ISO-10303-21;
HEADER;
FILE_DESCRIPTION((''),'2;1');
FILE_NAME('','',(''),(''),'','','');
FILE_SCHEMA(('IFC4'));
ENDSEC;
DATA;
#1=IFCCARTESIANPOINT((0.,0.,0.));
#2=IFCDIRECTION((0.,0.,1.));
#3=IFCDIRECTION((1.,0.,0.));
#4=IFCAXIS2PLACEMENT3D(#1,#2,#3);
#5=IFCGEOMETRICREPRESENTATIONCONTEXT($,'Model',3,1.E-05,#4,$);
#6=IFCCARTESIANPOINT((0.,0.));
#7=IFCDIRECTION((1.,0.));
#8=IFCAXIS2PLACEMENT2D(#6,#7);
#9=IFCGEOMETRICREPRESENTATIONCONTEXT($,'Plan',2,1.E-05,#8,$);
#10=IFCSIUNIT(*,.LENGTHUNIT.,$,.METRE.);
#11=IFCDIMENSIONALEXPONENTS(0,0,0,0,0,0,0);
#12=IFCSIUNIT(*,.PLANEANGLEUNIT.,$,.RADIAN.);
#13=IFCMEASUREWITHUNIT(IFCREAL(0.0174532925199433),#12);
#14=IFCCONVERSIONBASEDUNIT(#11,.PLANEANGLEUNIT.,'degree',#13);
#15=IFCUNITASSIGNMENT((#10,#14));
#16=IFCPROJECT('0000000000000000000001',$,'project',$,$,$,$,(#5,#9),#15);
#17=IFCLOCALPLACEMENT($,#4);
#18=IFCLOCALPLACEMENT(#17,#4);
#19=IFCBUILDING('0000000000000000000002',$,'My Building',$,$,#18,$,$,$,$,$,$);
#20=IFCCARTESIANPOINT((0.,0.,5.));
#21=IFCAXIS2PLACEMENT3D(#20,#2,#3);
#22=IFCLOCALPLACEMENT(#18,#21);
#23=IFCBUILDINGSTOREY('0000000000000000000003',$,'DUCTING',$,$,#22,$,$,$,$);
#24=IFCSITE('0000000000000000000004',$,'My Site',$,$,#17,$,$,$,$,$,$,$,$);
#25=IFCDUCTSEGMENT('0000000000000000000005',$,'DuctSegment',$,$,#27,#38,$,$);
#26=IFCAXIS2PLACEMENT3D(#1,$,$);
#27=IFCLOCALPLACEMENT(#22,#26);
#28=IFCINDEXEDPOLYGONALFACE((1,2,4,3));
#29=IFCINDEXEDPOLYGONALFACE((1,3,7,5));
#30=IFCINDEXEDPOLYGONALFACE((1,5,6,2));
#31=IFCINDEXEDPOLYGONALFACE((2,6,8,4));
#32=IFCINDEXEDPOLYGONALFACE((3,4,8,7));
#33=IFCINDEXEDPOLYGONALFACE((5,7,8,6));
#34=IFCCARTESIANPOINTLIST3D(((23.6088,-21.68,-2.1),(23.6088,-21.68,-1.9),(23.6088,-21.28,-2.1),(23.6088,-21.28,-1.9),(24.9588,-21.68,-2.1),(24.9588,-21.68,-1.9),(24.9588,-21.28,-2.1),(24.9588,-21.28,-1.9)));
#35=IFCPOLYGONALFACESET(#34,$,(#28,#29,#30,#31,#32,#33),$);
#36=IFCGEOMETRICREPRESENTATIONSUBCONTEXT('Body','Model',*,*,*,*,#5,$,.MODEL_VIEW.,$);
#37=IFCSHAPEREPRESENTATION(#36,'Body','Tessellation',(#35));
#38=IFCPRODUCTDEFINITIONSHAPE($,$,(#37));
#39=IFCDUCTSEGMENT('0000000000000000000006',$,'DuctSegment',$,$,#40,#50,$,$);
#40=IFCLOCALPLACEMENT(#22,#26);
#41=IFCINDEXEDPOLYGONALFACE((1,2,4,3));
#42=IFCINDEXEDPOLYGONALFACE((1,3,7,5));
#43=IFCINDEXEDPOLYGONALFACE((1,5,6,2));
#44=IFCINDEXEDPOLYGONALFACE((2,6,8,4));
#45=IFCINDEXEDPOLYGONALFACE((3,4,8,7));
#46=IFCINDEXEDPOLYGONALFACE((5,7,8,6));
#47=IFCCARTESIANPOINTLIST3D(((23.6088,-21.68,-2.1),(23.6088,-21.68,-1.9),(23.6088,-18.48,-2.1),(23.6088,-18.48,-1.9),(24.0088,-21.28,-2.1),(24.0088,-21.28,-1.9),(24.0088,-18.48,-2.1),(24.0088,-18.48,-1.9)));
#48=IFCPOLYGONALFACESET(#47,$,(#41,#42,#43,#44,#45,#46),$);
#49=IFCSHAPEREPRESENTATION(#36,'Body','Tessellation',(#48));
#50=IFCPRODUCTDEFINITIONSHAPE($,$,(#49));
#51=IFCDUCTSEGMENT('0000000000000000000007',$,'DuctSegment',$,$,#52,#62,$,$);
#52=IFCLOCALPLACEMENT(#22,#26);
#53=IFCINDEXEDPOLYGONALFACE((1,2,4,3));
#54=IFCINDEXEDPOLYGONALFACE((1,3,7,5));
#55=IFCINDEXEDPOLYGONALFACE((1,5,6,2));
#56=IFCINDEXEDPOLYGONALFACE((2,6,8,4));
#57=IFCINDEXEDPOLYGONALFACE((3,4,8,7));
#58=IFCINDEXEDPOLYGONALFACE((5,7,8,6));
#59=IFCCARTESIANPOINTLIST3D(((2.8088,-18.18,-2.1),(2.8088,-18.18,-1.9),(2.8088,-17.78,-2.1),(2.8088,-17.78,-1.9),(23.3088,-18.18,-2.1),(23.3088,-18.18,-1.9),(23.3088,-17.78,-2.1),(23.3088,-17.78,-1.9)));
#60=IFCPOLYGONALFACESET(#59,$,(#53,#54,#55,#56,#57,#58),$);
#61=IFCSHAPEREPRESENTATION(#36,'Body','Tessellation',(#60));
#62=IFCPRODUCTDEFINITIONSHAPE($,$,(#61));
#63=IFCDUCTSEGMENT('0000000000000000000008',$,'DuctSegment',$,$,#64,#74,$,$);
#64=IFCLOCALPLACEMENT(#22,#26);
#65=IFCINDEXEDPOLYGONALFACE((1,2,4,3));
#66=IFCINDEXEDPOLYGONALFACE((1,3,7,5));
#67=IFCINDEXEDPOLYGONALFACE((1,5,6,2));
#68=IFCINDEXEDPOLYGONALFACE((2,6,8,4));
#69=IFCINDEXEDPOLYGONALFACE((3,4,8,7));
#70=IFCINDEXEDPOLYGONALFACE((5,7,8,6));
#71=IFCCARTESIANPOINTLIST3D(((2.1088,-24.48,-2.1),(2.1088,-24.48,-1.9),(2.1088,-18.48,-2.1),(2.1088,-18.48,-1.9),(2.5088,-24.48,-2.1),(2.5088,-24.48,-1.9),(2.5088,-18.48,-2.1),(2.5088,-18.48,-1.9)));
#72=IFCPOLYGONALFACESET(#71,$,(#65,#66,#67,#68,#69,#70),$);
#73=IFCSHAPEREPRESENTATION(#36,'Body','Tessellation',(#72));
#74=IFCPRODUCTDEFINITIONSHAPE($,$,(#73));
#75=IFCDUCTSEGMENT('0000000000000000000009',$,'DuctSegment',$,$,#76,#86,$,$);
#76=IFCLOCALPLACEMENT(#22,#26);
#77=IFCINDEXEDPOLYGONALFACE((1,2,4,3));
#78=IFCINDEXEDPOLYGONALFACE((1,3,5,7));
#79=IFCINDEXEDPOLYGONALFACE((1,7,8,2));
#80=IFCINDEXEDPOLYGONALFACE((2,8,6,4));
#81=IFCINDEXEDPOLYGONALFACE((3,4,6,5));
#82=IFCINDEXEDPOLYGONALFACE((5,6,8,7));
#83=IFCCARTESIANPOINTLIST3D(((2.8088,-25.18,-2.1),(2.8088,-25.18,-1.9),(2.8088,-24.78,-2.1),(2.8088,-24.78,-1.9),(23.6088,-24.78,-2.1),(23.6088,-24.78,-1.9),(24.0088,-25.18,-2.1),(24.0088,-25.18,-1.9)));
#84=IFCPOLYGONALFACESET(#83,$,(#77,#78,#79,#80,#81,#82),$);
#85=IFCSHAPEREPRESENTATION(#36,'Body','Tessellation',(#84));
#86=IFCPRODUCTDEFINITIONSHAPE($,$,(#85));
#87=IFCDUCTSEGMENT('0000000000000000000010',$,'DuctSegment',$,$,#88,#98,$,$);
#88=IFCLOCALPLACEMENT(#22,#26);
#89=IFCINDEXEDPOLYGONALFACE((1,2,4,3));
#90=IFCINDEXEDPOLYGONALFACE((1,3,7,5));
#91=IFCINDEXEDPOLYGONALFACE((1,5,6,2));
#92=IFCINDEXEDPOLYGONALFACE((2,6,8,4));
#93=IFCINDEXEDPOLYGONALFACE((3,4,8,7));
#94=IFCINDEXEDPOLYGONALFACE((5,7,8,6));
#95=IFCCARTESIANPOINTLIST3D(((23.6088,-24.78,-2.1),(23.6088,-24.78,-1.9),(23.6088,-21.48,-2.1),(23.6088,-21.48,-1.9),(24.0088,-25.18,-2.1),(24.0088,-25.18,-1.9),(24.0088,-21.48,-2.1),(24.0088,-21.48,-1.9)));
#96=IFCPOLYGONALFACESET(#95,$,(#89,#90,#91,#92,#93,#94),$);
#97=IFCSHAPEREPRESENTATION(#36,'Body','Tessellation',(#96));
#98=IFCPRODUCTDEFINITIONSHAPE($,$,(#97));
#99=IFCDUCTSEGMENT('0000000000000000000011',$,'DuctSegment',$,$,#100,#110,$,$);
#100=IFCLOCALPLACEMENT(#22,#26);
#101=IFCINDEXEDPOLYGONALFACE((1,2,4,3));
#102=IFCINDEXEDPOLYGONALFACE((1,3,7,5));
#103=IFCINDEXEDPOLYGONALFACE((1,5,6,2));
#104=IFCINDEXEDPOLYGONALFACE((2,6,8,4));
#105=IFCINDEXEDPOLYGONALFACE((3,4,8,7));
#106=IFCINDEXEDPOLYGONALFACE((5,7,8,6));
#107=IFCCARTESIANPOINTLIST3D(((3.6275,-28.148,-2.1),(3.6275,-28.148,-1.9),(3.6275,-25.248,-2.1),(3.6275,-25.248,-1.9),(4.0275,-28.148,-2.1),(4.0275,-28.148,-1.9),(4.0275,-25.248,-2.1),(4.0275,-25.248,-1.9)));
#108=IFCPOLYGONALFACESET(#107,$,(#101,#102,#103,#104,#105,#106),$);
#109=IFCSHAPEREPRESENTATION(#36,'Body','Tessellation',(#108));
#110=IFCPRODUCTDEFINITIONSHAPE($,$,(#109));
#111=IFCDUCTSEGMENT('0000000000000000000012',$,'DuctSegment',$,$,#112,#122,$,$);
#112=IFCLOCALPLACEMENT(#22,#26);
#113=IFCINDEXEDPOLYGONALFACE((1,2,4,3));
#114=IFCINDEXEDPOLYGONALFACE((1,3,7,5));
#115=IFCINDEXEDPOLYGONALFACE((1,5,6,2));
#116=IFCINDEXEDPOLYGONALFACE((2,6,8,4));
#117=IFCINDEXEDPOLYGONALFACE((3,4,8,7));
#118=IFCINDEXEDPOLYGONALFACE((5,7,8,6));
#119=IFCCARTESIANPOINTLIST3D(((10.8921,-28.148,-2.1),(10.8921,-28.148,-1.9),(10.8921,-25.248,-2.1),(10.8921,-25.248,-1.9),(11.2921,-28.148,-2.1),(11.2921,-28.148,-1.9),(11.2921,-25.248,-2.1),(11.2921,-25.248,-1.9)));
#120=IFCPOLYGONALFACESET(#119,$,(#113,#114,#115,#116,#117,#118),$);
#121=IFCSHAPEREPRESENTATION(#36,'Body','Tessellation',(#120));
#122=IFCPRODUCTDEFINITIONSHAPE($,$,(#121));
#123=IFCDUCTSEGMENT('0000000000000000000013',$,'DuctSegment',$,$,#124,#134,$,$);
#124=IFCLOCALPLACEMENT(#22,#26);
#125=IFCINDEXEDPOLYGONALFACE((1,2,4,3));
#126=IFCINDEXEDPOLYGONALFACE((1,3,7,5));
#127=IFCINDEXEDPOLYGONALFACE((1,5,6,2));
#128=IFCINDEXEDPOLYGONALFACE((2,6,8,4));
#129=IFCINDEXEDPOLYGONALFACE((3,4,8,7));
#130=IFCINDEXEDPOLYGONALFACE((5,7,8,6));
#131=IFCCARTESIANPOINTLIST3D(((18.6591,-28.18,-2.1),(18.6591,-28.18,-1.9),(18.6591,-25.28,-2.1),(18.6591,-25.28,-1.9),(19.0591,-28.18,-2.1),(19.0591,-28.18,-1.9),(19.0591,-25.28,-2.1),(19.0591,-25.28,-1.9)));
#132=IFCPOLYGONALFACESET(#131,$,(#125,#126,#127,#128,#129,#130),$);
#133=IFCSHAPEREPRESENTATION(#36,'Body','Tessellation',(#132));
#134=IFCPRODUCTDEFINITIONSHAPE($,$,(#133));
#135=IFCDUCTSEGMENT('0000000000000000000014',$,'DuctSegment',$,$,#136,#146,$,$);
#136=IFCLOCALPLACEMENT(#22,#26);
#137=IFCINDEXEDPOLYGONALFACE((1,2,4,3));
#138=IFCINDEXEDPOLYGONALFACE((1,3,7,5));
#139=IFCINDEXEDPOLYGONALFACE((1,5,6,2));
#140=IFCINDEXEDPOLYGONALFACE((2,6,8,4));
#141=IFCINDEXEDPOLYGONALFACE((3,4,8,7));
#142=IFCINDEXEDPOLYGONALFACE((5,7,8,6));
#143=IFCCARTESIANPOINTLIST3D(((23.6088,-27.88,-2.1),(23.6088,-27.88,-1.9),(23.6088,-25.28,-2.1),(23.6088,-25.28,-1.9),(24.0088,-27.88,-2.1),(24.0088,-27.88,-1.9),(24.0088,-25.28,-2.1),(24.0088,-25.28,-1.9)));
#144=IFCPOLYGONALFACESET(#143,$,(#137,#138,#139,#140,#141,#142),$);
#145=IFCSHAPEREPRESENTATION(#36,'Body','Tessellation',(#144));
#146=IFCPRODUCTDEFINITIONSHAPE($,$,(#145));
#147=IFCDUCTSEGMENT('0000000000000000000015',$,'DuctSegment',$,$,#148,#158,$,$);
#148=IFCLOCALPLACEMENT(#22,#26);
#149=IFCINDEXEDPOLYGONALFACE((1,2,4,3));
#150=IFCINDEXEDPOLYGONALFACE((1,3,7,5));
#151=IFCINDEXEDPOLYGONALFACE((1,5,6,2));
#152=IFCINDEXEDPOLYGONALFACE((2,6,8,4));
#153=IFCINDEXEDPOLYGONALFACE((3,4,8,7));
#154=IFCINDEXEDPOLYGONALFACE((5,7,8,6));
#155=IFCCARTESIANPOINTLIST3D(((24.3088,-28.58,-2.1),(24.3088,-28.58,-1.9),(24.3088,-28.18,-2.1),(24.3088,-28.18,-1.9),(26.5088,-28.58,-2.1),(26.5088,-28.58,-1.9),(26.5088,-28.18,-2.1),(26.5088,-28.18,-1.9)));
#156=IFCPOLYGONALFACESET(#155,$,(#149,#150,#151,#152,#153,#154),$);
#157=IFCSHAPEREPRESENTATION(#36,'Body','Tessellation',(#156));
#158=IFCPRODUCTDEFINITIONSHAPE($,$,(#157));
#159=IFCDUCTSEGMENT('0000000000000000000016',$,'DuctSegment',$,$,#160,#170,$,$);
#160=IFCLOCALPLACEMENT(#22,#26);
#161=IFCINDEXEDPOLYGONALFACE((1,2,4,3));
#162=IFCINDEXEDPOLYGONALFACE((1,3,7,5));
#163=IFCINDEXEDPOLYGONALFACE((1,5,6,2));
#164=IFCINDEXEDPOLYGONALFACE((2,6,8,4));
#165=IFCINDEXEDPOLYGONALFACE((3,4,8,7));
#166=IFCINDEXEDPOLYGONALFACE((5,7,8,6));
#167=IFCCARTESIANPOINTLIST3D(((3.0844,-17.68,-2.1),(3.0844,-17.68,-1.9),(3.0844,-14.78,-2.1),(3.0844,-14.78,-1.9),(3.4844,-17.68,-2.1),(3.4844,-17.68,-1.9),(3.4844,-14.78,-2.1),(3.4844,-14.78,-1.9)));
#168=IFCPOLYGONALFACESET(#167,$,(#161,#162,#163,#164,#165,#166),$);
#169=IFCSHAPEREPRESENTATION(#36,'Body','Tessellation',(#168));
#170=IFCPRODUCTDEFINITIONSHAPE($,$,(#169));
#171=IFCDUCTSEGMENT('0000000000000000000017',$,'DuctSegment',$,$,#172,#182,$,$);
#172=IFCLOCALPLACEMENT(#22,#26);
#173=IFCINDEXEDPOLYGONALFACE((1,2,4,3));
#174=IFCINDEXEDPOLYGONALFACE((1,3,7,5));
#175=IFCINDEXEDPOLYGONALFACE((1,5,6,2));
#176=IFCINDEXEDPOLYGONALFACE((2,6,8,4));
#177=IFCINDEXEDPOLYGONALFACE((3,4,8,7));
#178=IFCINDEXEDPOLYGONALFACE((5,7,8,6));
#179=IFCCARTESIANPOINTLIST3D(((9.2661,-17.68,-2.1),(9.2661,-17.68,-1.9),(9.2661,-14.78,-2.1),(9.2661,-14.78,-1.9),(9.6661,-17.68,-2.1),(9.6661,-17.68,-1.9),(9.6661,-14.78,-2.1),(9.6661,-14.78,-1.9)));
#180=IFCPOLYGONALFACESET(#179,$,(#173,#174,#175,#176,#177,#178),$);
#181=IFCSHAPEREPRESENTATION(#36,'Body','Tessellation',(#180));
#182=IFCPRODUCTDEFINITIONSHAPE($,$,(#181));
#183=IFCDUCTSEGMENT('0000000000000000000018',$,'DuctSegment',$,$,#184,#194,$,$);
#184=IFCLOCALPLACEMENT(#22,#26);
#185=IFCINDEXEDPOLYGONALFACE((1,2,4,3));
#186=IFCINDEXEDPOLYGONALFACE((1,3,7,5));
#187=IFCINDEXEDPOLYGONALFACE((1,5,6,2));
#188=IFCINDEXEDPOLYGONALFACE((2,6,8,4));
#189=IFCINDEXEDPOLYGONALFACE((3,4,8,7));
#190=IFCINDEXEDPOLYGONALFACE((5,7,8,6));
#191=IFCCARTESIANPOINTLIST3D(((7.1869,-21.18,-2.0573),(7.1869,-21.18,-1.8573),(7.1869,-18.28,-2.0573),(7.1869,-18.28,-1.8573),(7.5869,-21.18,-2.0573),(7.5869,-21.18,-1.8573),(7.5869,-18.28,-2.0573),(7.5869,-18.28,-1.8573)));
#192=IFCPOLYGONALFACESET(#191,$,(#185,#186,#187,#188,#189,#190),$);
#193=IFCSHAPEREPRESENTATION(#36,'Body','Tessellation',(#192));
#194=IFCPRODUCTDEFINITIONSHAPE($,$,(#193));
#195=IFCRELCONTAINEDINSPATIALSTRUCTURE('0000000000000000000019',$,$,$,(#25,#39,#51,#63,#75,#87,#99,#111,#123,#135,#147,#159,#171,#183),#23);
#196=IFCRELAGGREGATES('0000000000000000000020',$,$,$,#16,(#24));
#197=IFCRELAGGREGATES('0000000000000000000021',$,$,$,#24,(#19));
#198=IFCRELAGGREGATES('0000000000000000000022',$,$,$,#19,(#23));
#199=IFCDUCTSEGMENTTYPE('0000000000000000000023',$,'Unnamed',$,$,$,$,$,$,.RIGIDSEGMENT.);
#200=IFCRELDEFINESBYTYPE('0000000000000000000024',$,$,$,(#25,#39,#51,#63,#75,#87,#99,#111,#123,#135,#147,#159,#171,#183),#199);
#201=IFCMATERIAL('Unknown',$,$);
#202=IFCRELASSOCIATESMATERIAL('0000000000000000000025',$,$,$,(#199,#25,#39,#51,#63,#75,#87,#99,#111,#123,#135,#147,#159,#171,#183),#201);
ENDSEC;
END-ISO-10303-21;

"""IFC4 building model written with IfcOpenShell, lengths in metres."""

from ifc_helpers import new_model, entity, si_unit, converted_unit, frame, origin_with_axes, origin_2d_with_axis, place, context, subcontext, project, spatial, rectangle, extrude, clip, halfspace, material, material_profile, profile_set, profile_usage, type_object, element, save


model = new_model("IFC4")

# Units and contexts
model_context = context("Model", 3, precision=1e-05, world=origin_with_axes())
plan_context = context("Plan", 2, precision=1e-05, world=origin_2d_with_axis())
body_context = subcontext(model_context, "Body", "Model", "MODEL_VIEW")
ifc_project = project(units=[si_unit("LENGTHUNIT", "METRE"), converted_unit("PLANEANGLEUNIT", "degree", entity("IfcReal", 0.0174532925199433), si_unit("PLANEANGLEUNIT", "RADIAN"), dimensions=[0, 0, 0, 0, 0, 0, 0])], contexts=[model_context, plan_context])

# Site, building, storey
site_placement = place(None, origin_with_axes())
site = spatial("IfcSite", under=ifc_project, at=site_placement, Name="My Site")
building_placement = place(site_placement, origin_with_axes())
building = spatial("IfcBuilding", under=site, at=building_placement, Name="My Building")
storey_placement = place(building_placement, frame((0.0, 0.0, 5.0), z_axis=(0.0, 0.0, 1.0), x_axis=(1.0, 0.0, 0.0)))
storey = spatial("IfcBuildingStorey", under=building, at=storey_placement, Name="DUCTING")

# Duct segments
ifc_material = material(Name="Unknown")
ifc_material_profile_1 = material_profile(ifc_material, rectangle(XDim=0.4, YDim=0.2))
ifc_profile_set_1 = profile_set([ifc_material_profile_1])
ifc_profile_usage_1 = profile_usage(ifc_profile_set_1, cardinal=5)
duct_segment_type = type_object("IfcDuctSegmentType", Name="Unnamed", PredefinedType="RIGIDSEGMENT", material=ifc_profile_set_1)
duct_segment_1_placement = place(storey_placement, frame((24.9588, -21.48, -2.0), z_axis=(-1.0, -0.000001, 0.000001), x_axis=(0.000001, -1.0, 0.0)))
element("IfcDuctSegment", 1, at=duct_segment_1_placement, inside=storey, type_object=duct_segment_type, material=ifc_profile_usage_1, Name="DuctSegment", context=body_context, shape_type="SweptSolid", body=[
    extrude(rectangle(XDim=0.4, YDim=0.2), origin_with_axes(), (0.0, 0.0, 1.0), 1.35),
])
ifc_profile_usage_2 = profile_usage(ifc_profile_set_1, cardinal=5)
duct_segment_2_placement = place(storey_placement, frame((23.8088, -21.68, -2.0), z_axis=(0.0, 1.0, 0.0), x_axis=(-1.0, 0.0, 0.0)))
element("IfcDuctSegment", 2, at=duct_segment_2_placement, inside=storey, type_object=duct_segment_type, material=ifc_profile_usage_2, Name="DuctSegment", context=body_context, shape_type="Clipping", body=[
    clip(extrude(rectangle(XDim=0.4, YDim=0.2), origin_with_axes(), (0.0, 0.0, 1.0), 3.2), halfspace(frame((0.2, -3.0, 0.0), z_axis=(-0.707107, 0.0, -0.707107), x_axis=(0.000001, 1.0, 0.0)), False)),
])
ifc_profile_usage_3 = profile_usage(ifc_profile_set_1, cardinal=5)
duct_segment_3_placement = place(storey_placement, frame((23.3088, -17.98, -2.0), z_axis=(-1.0, 0.0, 0.0), x_axis=(0.0, -1.0, 0.0)))
element("IfcDuctSegment", 3, at=duct_segment_3_placement, inside=storey, type_object=duct_segment_type, material=ifc_profile_usage_3, Name="DuctSegment", context=body_context, shape_type="SweptSolid", body=[
    extrude(rectangle(XDim=0.4, YDim=0.2), origin_with_axes(), (0.0, 0.0, 1.0), 20.5),
])
ifc_profile_usage_4 = profile_usage(ifc_profile_set_1, cardinal=5)
duct_segment_4_placement = place(storey_placement, frame((2.3088, -18.48, -2.0), z_axis=(0.0, -1.0, 0.0), x_axis=(1.0, 0.0, 0.0)))
element("IfcDuctSegment", 4, at=duct_segment_4_placement, inside=storey, type_object=duct_segment_type, material=ifc_profile_usage_4, Name="DuctSegment", context=body_context, shape_type="SweptSolid", body=[
    extrude(rectangle(XDim=0.4, YDim=0.2), origin_with_axes(), (0.0, 0.0, 1.0), 6.0),
])
ifc_profile_usage_5 = profile_usage(ifc_profile_set_1, cardinal=5)
duct_segment_5_placement = place(storey_placement, frame((2.8088, -24.98, -2.0), z_axis=(1.0, 0.0, 0.0), x_axis=(0.0, 1.0, 0.0)))
element("IfcDuctSegment", 5, at=duct_segment_5_placement, inside=storey, type_object=duct_segment_type, material=ifc_profile_usage_5, Name="DuctSegment", context=body_context, shape_type="Clipping", body=[
    clip(extrude(rectangle(XDim=0.4, YDim=0.2), origin_with_axes(), (0.0, 0.0, 1.0), 21.2), halfspace(frame((-0.2, -3.0, 21.2), z_axis=(0.707109, 0.0, 0.707105), x_axis=(0.0, -1.0, 0.0)), False)),
])
ifc_profile_usage_6 = profile_usage(ifc_profile_set_1, cardinal=5)
duct_segment_6_placement = place(storey_placement, frame((23.8088, -25.18, -2.0), z_axis=(0.0, 1.0, 0.0), x_axis=(-1.0, 0.0, 0.0)))
element("IfcDuctSegment", 6, at=duct_segment_6_placement, inside=storey, type_object=duct_segment_type, material=ifc_profile_usage_6, Name="DuctSegment", context=body_context, shape_type="Clipping", body=[
    clip(extrude(rectangle(XDim=0.4, YDim=0.2), origin_with_axes(), (0.0, 0.0, 1.0), 3.7), halfspace(frame((-0.2, -3.0, 0.0), z_axis=(0.707105, 0.0, -0.707108), x_axis=(0.0, -1.0, 0.0)), False)),
])
ifc_profile_usage_7 = profile_usage(ifc_profile_set_1, cardinal=5)
duct_segment_7_placement = place(storey_placement, frame((3.8275, -25.248, -2.0), z_axis=(0.0, -1.0, 0.000002), x_axis=(1.0, 0.0, 0.0)))
element("IfcDuctSegment", 7, at=duct_segment_7_placement, inside=storey, type_object=duct_segment_type, material=ifc_profile_usage_7, Name="DuctSegment", context=body_context, shape_type="SweptSolid", body=[
    extrude(rectangle(XDim=0.4, YDim=0.2), origin_with_axes(), (0.0, 0.0, 1.0), 2.9),
])
ifc_profile_usage_8 = profile_usage(ifc_profile_set_1, cardinal=5)
duct_segment_8_placement = place(storey_placement, frame((11.0921, -25.248, -2.0), z_axis=(0.0, -1.0, 0.000002), x_axis=(1.0, 0.0, 0.0)))
element("IfcDuctSegment", 8, at=duct_segment_8_placement, inside=storey, type_object=duct_segment_type, material=ifc_profile_usage_8, Name="DuctSegment", context=body_context, shape_type="SweptSolid", body=[
    extrude(rectangle(XDim=0.4, YDim=0.2), origin_with_axes(), (0.0, 0.0, 1.0), 2.9),
])
ifc_profile_usage_9 = profile_usage(ifc_profile_set_1, cardinal=5)
duct_segment_9_placement = place(storey_placement, frame((18.8591, -25.28, -2.0), z_axis=(0.0, -1.0, 0.000002), x_axis=(1.0, 0.0, 0.0)))
element("IfcDuctSegment", 9, at=duct_segment_9_placement, inside=storey, type_object=duct_segment_type, material=ifc_profile_usage_9, Name="DuctSegment", context=body_context, shape_type="SweptSolid", body=[
    extrude(rectangle(XDim=0.4, YDim=0.2), origin_with_axes(), (0.0, 0.0, 1.0), 2.9),
])
ifc_profile_usage_10 = profile_usage(ifc_profile_set_1, cardinal=5)
duct_segment_10_placement = place(storey_placement, frame((23.8088, -25.28, -2.0), z_axis=(0.0, -1.0, 0.000002), x_axis=(1.0, 0.0, 0.0)))
element("IfcDuctSegment", 10, at=duct_segment_10_placement, inside=storey, type_object=duct_segment_type, material=ifc_profile_usage_10, Name="DuctSegment", context=body_context, shape_type="SweptSolid", body=[
    extrude(rectangle(XDim=0.4, YDim=0.2), origin_with_axes(), (0.0, 0.0, 1.0), 2.6),
])
ifc_profile_usage_11 = profile_usage(ifc_profile_set_1, cardinal=5)
duct_segment_11_placement = place(storey_placement, frame((24.3088, -28.38, -2.0), z_axis=(1.0, -0.000001, 0.000001), x_axis=(0.000001, 1.0, 0.0)))
element("IfcDuctSegment", 11, at=duct_segment_11_placement, inside=storey, type_object=duct_segment_type, material=ifc_profile_usage_11, Name="DuctSegment", context=body_context, shape_type="SweptSolid", body=[
    extrude(rectangle(XDim=0.4, YDim=0.2), origin_with_axes(), (0.0, 0.0, 1.0), 2.2),
])
ifc_profile_usage_12 = profile_usage(ifc_profile_set_1, cardinal=5)
duct_segment_12_placement = place(storey_placement, frame((3.2844, -17.68, -2.0), z_axis=(0.0, 1.0, 0.000001), x_axis=(-1.0, 0.0, 0.0)))
element("IfcDuctSegment", 12, at=duct_segment_12_placement, inside=storey, type_object=duct_segment_type, material=ifc_profile_usage_12, Name="DuctSegment", context=body_context, shape_type="SweptSolid", body=[
    extrude(rectangle(XDim=0.4, YDim=0.2), origin_with_axes(), (0.0, 0.0, 1.0), 2.9),
])
ifc_profile_usage_13 = profile_usage(ifc_profile_set_1, cardinal=5)
duct_segment_13_placement = place(storey_placement, frame((9.4661, -17.68, -2.0), z_axis=(0.0, 1.0, 0.000001), x_axis=(-1.0, 0.0, 0.0)))
element("IfcDuctSegment", 13, at=duct_segment_13_placement, inside=storey, type_object=duct_segment_type, material=ifc_profile_usage_13, Name="DuctSegment", context=body_context, shape_type="SweptSolid", body=[
    extrude(rectangle(XDim=0.4, YDim=0.2), origin_with_axes(), (0.0, 0.0, 1.0), 2.9),
])
ifc_profile_usage_14 = profile_usage(ifc_profile_set_1, cardinal=5)
duct_segment_14_placement = place(storey_placement, frame((7.3869, -21.18, -1.9573), z_axis=(0.0, 1.0, 0.000001), x_axis=(-1.0, 0.0, 0.0)))
element("IfcDuctSegment", 14, at=duct_segment_14_placement, inside=storey, type_object=duct_segment_type, material=ifc_profile_usage_14, Name="DuctSegment", context=body_context, shape_type="SweptSolid", body=[
    extrude(rectangle(XDim=0.4, YDim=0.2), origin_with_axes(), (0.0, 0.0, 1.0), 2.9),
])

save(model, "model.ifc")
